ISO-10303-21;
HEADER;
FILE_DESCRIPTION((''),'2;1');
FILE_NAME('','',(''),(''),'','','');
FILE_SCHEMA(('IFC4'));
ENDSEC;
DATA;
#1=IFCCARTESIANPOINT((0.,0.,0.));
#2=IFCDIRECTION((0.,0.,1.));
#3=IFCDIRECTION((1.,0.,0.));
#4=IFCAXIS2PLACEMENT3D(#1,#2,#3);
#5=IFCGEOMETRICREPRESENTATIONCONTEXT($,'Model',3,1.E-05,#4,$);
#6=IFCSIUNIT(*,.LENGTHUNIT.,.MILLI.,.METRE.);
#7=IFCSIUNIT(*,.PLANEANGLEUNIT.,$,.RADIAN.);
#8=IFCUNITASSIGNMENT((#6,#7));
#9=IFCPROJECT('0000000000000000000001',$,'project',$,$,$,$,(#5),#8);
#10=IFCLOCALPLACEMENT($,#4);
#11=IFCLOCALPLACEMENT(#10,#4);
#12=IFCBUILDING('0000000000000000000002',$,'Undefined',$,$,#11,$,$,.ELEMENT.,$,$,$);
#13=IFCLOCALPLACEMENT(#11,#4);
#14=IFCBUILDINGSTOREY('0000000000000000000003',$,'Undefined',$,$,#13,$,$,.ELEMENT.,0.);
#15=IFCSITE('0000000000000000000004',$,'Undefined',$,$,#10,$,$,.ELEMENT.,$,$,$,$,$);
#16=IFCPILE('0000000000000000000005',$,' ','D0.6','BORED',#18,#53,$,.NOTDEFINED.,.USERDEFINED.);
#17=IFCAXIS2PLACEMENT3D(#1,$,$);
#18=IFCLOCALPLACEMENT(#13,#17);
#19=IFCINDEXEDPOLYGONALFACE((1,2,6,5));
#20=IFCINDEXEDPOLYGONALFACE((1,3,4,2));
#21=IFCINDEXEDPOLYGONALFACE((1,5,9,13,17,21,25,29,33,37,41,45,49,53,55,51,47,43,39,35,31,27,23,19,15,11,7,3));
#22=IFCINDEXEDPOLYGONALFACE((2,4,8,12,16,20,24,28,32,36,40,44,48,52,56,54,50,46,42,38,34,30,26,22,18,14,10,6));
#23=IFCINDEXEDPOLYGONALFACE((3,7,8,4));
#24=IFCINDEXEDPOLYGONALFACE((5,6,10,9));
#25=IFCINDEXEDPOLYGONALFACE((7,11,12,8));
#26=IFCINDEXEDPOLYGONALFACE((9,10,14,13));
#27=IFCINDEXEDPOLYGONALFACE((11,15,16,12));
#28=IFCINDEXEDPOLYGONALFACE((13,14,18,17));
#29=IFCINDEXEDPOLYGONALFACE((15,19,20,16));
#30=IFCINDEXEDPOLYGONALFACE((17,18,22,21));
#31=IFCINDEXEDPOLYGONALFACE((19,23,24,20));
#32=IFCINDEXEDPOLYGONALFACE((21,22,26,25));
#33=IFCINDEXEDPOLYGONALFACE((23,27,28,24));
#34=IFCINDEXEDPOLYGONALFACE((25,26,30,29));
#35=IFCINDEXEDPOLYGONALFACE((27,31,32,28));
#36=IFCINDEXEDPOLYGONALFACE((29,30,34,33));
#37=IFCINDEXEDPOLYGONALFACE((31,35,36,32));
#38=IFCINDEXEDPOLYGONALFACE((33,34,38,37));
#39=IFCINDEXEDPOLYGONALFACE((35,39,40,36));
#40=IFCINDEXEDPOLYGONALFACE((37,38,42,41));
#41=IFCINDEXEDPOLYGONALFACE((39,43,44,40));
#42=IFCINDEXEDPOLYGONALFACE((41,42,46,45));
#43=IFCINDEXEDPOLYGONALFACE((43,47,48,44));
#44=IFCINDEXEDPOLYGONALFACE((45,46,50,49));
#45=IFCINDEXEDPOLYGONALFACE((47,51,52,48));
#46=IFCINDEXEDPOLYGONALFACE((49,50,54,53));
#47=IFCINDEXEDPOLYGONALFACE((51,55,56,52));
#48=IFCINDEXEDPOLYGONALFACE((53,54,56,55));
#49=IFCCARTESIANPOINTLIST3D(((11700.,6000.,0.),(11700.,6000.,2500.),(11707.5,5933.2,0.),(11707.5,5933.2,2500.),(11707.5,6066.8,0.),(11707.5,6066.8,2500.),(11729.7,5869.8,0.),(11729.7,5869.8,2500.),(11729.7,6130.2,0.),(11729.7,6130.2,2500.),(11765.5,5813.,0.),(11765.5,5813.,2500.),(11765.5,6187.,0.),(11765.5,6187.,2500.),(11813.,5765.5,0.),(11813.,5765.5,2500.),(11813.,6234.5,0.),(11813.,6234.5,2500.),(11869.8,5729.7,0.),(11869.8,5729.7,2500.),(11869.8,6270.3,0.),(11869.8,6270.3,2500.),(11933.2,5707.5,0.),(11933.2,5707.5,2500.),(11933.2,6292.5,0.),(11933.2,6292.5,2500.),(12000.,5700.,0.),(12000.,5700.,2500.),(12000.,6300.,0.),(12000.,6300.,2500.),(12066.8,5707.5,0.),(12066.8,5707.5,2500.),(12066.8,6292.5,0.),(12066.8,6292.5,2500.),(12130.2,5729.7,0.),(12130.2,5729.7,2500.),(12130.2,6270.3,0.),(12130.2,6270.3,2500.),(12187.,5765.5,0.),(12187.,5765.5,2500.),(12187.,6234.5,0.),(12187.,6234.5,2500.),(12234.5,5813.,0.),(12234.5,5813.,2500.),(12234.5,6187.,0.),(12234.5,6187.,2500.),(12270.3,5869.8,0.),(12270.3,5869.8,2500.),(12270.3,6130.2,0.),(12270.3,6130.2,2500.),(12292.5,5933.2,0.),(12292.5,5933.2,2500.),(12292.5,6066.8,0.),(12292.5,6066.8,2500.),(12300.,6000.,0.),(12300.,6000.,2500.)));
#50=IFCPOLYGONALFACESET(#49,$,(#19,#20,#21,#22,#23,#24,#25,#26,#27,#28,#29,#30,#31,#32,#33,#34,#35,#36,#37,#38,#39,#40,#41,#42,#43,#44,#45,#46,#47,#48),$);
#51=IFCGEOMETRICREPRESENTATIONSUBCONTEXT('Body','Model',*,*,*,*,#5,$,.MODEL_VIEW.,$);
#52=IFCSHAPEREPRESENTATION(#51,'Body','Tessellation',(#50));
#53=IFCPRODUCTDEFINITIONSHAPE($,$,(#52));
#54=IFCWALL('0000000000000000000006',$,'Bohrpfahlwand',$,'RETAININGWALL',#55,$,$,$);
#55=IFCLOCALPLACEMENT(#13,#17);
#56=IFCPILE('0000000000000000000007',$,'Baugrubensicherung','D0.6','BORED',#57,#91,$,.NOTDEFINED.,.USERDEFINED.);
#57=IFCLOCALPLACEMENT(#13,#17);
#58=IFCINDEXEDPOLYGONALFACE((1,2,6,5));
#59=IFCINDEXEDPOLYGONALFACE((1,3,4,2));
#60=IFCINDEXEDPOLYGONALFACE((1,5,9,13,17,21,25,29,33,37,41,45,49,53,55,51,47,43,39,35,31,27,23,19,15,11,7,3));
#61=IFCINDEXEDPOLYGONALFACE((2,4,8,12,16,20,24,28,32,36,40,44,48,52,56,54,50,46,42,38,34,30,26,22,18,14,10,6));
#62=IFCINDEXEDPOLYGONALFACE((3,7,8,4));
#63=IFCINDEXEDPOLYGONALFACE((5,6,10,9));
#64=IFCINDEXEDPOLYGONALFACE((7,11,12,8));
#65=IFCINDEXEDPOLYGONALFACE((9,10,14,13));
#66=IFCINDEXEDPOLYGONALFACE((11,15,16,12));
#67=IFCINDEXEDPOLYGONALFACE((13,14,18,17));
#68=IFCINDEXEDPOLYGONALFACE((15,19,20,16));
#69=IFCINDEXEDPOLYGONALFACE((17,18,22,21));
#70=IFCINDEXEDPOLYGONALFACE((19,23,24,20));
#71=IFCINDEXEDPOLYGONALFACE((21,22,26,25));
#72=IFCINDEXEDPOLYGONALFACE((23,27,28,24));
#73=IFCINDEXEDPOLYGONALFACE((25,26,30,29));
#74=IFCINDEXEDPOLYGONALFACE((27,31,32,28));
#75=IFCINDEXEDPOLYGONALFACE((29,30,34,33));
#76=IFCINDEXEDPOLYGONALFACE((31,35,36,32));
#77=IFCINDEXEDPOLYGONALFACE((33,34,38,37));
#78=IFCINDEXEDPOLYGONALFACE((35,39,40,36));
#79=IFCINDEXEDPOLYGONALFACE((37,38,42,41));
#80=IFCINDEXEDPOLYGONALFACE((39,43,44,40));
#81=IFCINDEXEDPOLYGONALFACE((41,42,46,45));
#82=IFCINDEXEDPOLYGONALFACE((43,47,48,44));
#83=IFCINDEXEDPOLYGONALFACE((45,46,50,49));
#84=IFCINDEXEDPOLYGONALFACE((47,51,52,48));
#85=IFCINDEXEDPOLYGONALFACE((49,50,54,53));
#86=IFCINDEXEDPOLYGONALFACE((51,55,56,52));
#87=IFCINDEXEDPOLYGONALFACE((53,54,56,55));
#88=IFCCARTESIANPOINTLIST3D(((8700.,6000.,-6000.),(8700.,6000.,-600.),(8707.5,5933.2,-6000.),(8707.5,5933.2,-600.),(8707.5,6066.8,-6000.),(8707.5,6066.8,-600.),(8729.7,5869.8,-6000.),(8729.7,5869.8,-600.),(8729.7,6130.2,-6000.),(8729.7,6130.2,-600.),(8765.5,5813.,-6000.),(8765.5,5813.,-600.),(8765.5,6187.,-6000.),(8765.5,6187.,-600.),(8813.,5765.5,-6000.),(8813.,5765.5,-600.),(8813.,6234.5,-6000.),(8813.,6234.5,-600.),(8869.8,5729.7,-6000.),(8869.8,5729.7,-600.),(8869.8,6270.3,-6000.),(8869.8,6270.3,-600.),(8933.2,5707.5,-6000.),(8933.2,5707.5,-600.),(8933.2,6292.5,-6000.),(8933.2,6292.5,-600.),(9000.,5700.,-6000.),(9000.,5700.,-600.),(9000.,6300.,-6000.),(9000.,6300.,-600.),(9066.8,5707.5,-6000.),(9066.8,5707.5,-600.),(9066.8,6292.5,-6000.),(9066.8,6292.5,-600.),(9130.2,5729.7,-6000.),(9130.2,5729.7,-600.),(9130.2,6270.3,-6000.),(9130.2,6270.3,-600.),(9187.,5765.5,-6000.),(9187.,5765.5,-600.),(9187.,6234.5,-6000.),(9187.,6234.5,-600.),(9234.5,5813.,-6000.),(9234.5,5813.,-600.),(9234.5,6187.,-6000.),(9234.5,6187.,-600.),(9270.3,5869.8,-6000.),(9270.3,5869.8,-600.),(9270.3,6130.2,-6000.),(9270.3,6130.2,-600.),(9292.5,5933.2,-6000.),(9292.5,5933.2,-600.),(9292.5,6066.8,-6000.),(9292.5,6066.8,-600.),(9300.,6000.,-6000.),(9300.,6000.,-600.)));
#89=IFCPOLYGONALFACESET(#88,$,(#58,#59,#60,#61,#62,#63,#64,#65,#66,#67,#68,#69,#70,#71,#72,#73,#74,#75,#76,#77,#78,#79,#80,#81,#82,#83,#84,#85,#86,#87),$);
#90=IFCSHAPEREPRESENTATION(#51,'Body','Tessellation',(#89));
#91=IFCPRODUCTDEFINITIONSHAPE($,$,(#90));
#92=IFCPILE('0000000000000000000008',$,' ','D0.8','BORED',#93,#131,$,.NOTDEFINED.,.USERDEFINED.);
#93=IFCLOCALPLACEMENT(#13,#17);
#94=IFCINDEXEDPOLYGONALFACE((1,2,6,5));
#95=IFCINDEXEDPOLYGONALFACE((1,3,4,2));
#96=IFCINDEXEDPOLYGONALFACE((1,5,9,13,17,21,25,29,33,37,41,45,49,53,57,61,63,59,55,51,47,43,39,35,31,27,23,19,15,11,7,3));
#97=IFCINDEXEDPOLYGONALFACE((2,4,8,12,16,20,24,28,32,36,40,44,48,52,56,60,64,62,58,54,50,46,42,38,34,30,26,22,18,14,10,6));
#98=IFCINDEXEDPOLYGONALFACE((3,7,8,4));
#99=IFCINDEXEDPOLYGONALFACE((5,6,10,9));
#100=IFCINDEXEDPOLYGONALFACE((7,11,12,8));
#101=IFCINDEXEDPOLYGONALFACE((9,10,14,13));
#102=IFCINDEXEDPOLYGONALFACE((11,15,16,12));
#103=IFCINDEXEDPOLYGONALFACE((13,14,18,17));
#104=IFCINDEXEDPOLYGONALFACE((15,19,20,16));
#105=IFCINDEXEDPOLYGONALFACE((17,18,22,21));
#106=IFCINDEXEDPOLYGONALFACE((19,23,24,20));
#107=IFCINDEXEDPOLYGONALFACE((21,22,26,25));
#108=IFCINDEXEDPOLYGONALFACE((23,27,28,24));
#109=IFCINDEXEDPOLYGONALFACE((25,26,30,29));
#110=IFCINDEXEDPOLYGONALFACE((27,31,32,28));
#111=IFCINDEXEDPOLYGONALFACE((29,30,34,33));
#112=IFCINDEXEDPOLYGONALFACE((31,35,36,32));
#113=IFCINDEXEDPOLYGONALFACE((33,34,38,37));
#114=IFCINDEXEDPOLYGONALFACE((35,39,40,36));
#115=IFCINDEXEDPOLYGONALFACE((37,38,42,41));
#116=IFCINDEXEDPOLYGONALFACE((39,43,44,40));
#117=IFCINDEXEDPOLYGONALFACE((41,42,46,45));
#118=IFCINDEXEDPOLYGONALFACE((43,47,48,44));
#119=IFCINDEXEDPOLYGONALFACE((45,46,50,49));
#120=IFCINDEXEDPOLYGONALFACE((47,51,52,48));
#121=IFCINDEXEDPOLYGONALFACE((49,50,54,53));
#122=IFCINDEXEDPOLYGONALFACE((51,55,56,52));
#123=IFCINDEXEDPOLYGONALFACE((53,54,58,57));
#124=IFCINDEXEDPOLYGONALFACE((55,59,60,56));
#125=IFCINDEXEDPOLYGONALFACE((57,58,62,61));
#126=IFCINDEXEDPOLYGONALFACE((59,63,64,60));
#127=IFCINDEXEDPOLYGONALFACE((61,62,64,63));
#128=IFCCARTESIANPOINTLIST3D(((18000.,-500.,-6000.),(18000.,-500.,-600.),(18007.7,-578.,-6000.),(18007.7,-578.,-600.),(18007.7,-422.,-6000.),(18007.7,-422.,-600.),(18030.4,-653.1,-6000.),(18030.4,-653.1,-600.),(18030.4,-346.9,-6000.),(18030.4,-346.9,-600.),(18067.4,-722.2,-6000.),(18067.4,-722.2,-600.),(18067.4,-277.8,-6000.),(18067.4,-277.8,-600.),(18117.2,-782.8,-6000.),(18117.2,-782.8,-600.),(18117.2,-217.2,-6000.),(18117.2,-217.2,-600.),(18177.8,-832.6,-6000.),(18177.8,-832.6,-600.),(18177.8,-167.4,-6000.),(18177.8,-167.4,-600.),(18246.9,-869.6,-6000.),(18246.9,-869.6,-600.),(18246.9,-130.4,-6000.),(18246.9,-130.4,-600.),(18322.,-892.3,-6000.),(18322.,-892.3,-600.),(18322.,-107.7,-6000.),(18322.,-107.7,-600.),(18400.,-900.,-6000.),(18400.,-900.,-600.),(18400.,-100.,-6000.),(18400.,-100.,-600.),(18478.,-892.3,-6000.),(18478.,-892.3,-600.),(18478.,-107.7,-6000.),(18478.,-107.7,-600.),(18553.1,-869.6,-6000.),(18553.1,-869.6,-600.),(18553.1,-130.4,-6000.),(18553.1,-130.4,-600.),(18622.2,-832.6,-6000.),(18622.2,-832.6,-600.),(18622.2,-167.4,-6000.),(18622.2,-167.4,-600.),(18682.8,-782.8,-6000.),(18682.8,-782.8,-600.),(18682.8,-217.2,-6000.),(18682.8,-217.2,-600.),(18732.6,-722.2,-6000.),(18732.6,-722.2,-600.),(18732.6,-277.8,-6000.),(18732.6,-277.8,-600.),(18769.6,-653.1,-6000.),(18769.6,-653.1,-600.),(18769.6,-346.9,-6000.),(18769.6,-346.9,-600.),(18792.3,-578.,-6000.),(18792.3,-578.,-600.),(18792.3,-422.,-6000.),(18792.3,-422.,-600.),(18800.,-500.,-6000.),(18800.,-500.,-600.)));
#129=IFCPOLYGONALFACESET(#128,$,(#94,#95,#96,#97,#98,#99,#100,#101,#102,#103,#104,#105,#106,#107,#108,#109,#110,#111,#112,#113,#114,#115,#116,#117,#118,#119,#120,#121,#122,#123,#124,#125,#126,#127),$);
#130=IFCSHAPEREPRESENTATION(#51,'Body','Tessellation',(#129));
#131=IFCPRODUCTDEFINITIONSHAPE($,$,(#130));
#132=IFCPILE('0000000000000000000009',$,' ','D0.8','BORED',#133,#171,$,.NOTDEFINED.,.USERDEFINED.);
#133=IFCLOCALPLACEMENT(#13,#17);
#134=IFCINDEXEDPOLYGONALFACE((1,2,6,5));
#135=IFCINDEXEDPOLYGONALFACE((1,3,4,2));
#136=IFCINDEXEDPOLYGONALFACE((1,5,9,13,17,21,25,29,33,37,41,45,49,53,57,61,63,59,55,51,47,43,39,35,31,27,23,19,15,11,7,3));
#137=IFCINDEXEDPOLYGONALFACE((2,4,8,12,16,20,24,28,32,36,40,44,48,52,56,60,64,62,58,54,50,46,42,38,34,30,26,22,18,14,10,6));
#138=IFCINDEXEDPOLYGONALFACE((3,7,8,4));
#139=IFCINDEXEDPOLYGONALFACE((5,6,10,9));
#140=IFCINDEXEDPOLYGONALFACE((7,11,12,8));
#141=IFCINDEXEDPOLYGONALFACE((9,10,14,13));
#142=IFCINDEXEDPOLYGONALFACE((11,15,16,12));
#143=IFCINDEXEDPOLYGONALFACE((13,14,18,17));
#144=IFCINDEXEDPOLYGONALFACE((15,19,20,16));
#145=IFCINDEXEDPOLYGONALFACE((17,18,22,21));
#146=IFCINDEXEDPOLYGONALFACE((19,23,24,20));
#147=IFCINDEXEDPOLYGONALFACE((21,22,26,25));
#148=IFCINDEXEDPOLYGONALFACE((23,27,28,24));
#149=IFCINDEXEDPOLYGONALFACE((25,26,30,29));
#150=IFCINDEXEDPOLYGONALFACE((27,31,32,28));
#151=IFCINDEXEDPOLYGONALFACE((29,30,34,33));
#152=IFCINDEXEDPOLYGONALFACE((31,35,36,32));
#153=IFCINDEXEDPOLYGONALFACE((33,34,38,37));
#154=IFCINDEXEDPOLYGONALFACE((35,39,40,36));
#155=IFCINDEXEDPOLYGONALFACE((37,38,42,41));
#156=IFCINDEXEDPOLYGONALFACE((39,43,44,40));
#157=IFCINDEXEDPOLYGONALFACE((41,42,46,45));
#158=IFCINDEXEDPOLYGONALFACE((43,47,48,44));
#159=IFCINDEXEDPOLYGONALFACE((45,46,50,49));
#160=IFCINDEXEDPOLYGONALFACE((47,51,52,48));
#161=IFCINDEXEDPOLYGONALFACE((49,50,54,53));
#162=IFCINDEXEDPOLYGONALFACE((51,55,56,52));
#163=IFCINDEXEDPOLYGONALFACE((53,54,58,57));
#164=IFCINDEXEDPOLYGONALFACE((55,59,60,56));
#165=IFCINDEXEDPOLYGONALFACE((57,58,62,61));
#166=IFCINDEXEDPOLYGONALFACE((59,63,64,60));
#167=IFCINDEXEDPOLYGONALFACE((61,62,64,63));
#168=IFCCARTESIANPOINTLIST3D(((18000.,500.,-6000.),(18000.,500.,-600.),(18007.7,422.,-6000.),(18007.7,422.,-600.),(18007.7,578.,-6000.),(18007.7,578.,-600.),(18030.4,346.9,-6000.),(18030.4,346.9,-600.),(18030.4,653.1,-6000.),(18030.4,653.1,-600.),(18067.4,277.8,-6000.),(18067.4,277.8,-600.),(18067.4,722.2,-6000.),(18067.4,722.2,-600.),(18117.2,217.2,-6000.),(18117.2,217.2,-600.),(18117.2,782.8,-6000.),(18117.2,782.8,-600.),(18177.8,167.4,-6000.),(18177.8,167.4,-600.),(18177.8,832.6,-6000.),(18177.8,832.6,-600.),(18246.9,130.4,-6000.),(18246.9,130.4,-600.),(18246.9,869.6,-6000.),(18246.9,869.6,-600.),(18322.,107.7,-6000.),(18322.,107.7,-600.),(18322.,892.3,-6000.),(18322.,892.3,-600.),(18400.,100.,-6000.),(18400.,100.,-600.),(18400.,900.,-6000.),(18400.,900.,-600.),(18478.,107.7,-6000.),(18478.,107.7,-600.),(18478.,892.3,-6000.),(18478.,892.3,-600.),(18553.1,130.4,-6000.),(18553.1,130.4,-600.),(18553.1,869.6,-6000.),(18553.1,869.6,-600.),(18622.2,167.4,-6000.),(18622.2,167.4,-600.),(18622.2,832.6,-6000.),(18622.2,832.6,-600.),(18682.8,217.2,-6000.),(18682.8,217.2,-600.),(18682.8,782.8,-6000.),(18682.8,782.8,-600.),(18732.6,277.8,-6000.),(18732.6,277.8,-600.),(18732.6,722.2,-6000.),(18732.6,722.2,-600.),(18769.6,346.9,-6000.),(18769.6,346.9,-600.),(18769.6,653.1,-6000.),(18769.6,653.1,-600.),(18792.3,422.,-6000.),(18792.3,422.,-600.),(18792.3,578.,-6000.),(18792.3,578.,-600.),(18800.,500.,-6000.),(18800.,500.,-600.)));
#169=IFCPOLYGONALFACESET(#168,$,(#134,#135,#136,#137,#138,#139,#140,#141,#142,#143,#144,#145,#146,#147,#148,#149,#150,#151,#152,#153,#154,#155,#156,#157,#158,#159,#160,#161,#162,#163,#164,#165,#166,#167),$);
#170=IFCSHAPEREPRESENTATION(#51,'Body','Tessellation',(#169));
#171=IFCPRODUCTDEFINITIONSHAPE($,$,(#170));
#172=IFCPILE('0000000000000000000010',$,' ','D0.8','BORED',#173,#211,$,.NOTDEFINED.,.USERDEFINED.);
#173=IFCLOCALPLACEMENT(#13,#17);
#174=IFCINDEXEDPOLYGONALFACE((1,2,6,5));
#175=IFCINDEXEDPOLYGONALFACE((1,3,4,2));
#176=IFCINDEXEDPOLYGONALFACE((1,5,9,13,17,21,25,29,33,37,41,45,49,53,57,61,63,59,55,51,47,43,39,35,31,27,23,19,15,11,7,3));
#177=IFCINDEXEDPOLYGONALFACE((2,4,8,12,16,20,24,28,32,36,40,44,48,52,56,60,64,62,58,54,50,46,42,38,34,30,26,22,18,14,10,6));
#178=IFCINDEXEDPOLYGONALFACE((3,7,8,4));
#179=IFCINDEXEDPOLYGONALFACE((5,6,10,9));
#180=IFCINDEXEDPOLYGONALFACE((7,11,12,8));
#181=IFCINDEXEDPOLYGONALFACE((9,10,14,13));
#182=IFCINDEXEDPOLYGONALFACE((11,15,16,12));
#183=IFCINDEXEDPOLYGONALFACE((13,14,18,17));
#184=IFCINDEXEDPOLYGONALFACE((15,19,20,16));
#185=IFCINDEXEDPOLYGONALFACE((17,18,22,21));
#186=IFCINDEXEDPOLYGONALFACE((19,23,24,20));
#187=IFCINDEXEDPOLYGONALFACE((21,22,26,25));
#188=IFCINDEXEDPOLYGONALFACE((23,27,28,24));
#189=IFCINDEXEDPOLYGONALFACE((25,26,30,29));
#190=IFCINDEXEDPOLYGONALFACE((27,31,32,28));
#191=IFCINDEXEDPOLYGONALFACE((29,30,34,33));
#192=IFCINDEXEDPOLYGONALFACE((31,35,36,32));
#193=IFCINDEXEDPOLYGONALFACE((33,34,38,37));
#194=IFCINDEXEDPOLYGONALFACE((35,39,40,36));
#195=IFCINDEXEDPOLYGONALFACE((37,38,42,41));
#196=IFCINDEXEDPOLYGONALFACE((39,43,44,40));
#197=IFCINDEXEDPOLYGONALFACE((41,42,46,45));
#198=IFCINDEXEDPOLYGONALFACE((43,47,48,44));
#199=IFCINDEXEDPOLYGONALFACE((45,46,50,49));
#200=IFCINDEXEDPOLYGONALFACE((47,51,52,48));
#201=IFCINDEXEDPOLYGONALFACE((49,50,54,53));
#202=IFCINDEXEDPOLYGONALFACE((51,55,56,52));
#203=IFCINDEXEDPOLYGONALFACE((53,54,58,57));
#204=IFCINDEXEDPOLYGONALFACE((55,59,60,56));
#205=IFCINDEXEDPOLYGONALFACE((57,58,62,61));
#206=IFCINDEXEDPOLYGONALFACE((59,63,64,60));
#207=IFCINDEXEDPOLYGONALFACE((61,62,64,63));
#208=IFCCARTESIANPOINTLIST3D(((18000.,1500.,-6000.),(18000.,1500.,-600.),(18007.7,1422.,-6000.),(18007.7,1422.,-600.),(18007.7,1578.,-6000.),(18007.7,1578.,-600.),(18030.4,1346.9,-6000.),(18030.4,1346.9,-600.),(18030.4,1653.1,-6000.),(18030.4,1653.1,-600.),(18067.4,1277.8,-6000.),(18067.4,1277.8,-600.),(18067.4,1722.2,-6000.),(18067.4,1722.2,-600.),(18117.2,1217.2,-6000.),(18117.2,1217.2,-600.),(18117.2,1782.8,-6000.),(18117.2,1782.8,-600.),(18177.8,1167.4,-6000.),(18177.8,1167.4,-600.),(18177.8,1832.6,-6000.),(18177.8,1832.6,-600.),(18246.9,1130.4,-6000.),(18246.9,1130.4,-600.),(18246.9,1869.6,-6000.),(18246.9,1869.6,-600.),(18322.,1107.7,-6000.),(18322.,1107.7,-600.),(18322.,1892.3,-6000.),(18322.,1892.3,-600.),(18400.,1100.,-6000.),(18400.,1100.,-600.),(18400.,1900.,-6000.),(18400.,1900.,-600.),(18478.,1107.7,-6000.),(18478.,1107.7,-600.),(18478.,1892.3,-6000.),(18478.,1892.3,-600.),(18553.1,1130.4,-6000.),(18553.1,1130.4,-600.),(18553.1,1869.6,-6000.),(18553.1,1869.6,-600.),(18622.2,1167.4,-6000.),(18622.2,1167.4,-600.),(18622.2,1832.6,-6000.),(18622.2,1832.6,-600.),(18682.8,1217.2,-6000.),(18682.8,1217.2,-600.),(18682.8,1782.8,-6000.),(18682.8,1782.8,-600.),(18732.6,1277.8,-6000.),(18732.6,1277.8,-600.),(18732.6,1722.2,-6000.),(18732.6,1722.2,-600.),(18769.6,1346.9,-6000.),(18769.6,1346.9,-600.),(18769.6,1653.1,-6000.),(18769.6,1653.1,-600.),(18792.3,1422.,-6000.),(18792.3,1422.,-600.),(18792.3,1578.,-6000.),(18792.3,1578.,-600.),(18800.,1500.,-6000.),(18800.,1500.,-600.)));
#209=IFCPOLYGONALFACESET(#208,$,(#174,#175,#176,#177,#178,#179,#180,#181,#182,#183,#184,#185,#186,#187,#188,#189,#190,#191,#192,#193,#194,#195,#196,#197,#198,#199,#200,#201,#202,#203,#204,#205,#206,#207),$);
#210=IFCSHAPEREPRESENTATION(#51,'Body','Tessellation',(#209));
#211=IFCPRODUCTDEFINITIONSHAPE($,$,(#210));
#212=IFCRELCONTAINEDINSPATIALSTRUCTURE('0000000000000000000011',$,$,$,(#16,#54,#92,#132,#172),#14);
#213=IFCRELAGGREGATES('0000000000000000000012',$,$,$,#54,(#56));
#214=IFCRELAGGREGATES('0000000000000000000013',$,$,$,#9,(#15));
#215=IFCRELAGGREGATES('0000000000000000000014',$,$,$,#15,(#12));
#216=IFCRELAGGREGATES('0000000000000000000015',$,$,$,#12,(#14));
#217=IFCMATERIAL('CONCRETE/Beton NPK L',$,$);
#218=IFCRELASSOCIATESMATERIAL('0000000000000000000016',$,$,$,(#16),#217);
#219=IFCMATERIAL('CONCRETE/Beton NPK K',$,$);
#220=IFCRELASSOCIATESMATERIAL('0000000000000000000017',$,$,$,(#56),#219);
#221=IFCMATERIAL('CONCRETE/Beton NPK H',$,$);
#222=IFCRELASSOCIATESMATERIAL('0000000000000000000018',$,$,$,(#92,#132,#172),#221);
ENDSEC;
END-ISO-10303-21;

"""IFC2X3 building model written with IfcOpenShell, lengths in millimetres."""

from ifc_helpers import new_model, si_unit, frame, origin_with_axes, origin_2d_with_axis, place, context, subcontext, project, spatial, circle, extrude, material, element, aggregate, save


model = new_model("IFC2X3")

# Units and contexts
model_context = context("Model", 3, precision=1e-05, world=origin_with_axes())
body_context = subcontext(model_context, "Body", "Model", "MODEL_VIEW")
ifc_project = project(units=[si_unit("LENGTHUNIT", "METRE", prefix="MILLI"), si_unit("PLANEANGLEUNIT", "RADIAN")], contexts=[model_context])

# Site, building, storey
site_placement = place(None, origin_with_axes())
site = spatial("IfcSite", under=ifc_project, at=site_placement, Name="Undefined", CompositionType="ELEMENT")
building_placement = place(site_placement, origin_with_axes())
building = spatial("IfcBuilding", under=site, at=building_placement, Name="Undefined", CompositionType="ELEMENT")
storey_placement = place(building_placement, origin_with_axes())
storey = spatial("IfcBuildingStorey", under=building, at=storey_placement, Name="Undefined", CompositionType="ELEMENT", Elevation=0.0)

# Pile
ifc_material_1 = material(Name="CONCRETE/Beton NPK L")
pile_1_placement = place(storey_placement, frame((12000.0, 6000.0, 0.0), z_axis=(0.0, 1.0, 0.0), x_axis=(0.0, 0.0, 1.0)))
element("IfcPile", 1, at=pile_1_placement, inside=storey, material=ifc_material_1, Name=" ", Description="D0.6", ObjectType="BORED", ConstructionType="USERDEFINED", PredefinedType="NOTDEFINED", context=body_context, shape_type="SweptSolid", body=[
    extrude(circle(Radius=300.0, at=origin_2d_with_axis()), frame((2500.0, 0.0, 0.0), z_axis=(-1.0, 0.0, 0.0), x_axis=(0.0, -1.0, 0.0)), (0.0, 0.0, 1.0), 2500.0),
])

# Wall, pile
wall_placement = place(storey_placement, origin_with_axes())
wall = element("IfcWall", 2, at=wall_placement, inside=storey, Name="Bohrpfahlwand", ObjectType="RETAININGWALL")
ifc_material_2 = material(Name="CONCRETE/Beton NPK K")
pile_2_placement = place(wall_placement, frame((9000.0, 6000.0, -6000.0), z_axis=(0.0, 1.0, 0.0), x_axis=(0.0, 0.0, 1.0)))
pile_2 = element("IfcPile", 3, at=pile_2_placement, material=ifc_material_2, Name="Baugrubensicherung", Description="D0.6", ObjectType="BORED", ConstructionType="USERDEFINED", PredefinedType="NOTDEFINED", context=body_context, shape_type="SweptSolid", body=[
    extrude(circle(Radius=300.0, at=origin_2d_with_axis()), frame((5400.0, 0.0, 0.0), z_axis=(-1.0, 0.0, 0.0), x_axis=(0.0, -1.0, 0.0)), (0.0, 0.0, 1.0), 5400.0),
])

# Piles
ifc_material_3 = material(Name="CONCRETE/Beton NPK H")
for number, where, z_axis, x_axis, name in (
    (4, (18400.0, -500.0, -6000.0), (0.0, 1.0, 0.0), (0.0, 0.0, 1.0), " "),
    (5, (18400.0, 500.0, -6000.0), (0.0, 1.0, 0.0), (0.0, 0.0, 1.0), " "),
    (6, (18400.0, 1500.0, -6000.0), (0.0, 1.0, 0.0), (0.0, 0.0, 1.0), " "),
):
    element("IfcPile", number, at=place(storey_placement, frame(where, z_axis=z_axis, x_axis=x_axis)), inside=storey, material=ifc_material_3, Name=name, Description="D0.8", ObjectType="BORED", ConstructionType="USERDEFINED", PredefinedType="NOTDEFINED", context=body_context, shape_type="SweptSolid", body=[
        extrude(circle(Radius=400.0, at=origin_2d_with_axis()), frame((5400.0, 0.0, 0.0), z_axis=(-1.0, 0.0, 0.0), x_axis=(0.0, -1.0, 0.0)), (0.0, 0.0, 1.0), 5400.0),
    ])

aggregate(wall, [pile_2])

save(model, "model.ifc")
